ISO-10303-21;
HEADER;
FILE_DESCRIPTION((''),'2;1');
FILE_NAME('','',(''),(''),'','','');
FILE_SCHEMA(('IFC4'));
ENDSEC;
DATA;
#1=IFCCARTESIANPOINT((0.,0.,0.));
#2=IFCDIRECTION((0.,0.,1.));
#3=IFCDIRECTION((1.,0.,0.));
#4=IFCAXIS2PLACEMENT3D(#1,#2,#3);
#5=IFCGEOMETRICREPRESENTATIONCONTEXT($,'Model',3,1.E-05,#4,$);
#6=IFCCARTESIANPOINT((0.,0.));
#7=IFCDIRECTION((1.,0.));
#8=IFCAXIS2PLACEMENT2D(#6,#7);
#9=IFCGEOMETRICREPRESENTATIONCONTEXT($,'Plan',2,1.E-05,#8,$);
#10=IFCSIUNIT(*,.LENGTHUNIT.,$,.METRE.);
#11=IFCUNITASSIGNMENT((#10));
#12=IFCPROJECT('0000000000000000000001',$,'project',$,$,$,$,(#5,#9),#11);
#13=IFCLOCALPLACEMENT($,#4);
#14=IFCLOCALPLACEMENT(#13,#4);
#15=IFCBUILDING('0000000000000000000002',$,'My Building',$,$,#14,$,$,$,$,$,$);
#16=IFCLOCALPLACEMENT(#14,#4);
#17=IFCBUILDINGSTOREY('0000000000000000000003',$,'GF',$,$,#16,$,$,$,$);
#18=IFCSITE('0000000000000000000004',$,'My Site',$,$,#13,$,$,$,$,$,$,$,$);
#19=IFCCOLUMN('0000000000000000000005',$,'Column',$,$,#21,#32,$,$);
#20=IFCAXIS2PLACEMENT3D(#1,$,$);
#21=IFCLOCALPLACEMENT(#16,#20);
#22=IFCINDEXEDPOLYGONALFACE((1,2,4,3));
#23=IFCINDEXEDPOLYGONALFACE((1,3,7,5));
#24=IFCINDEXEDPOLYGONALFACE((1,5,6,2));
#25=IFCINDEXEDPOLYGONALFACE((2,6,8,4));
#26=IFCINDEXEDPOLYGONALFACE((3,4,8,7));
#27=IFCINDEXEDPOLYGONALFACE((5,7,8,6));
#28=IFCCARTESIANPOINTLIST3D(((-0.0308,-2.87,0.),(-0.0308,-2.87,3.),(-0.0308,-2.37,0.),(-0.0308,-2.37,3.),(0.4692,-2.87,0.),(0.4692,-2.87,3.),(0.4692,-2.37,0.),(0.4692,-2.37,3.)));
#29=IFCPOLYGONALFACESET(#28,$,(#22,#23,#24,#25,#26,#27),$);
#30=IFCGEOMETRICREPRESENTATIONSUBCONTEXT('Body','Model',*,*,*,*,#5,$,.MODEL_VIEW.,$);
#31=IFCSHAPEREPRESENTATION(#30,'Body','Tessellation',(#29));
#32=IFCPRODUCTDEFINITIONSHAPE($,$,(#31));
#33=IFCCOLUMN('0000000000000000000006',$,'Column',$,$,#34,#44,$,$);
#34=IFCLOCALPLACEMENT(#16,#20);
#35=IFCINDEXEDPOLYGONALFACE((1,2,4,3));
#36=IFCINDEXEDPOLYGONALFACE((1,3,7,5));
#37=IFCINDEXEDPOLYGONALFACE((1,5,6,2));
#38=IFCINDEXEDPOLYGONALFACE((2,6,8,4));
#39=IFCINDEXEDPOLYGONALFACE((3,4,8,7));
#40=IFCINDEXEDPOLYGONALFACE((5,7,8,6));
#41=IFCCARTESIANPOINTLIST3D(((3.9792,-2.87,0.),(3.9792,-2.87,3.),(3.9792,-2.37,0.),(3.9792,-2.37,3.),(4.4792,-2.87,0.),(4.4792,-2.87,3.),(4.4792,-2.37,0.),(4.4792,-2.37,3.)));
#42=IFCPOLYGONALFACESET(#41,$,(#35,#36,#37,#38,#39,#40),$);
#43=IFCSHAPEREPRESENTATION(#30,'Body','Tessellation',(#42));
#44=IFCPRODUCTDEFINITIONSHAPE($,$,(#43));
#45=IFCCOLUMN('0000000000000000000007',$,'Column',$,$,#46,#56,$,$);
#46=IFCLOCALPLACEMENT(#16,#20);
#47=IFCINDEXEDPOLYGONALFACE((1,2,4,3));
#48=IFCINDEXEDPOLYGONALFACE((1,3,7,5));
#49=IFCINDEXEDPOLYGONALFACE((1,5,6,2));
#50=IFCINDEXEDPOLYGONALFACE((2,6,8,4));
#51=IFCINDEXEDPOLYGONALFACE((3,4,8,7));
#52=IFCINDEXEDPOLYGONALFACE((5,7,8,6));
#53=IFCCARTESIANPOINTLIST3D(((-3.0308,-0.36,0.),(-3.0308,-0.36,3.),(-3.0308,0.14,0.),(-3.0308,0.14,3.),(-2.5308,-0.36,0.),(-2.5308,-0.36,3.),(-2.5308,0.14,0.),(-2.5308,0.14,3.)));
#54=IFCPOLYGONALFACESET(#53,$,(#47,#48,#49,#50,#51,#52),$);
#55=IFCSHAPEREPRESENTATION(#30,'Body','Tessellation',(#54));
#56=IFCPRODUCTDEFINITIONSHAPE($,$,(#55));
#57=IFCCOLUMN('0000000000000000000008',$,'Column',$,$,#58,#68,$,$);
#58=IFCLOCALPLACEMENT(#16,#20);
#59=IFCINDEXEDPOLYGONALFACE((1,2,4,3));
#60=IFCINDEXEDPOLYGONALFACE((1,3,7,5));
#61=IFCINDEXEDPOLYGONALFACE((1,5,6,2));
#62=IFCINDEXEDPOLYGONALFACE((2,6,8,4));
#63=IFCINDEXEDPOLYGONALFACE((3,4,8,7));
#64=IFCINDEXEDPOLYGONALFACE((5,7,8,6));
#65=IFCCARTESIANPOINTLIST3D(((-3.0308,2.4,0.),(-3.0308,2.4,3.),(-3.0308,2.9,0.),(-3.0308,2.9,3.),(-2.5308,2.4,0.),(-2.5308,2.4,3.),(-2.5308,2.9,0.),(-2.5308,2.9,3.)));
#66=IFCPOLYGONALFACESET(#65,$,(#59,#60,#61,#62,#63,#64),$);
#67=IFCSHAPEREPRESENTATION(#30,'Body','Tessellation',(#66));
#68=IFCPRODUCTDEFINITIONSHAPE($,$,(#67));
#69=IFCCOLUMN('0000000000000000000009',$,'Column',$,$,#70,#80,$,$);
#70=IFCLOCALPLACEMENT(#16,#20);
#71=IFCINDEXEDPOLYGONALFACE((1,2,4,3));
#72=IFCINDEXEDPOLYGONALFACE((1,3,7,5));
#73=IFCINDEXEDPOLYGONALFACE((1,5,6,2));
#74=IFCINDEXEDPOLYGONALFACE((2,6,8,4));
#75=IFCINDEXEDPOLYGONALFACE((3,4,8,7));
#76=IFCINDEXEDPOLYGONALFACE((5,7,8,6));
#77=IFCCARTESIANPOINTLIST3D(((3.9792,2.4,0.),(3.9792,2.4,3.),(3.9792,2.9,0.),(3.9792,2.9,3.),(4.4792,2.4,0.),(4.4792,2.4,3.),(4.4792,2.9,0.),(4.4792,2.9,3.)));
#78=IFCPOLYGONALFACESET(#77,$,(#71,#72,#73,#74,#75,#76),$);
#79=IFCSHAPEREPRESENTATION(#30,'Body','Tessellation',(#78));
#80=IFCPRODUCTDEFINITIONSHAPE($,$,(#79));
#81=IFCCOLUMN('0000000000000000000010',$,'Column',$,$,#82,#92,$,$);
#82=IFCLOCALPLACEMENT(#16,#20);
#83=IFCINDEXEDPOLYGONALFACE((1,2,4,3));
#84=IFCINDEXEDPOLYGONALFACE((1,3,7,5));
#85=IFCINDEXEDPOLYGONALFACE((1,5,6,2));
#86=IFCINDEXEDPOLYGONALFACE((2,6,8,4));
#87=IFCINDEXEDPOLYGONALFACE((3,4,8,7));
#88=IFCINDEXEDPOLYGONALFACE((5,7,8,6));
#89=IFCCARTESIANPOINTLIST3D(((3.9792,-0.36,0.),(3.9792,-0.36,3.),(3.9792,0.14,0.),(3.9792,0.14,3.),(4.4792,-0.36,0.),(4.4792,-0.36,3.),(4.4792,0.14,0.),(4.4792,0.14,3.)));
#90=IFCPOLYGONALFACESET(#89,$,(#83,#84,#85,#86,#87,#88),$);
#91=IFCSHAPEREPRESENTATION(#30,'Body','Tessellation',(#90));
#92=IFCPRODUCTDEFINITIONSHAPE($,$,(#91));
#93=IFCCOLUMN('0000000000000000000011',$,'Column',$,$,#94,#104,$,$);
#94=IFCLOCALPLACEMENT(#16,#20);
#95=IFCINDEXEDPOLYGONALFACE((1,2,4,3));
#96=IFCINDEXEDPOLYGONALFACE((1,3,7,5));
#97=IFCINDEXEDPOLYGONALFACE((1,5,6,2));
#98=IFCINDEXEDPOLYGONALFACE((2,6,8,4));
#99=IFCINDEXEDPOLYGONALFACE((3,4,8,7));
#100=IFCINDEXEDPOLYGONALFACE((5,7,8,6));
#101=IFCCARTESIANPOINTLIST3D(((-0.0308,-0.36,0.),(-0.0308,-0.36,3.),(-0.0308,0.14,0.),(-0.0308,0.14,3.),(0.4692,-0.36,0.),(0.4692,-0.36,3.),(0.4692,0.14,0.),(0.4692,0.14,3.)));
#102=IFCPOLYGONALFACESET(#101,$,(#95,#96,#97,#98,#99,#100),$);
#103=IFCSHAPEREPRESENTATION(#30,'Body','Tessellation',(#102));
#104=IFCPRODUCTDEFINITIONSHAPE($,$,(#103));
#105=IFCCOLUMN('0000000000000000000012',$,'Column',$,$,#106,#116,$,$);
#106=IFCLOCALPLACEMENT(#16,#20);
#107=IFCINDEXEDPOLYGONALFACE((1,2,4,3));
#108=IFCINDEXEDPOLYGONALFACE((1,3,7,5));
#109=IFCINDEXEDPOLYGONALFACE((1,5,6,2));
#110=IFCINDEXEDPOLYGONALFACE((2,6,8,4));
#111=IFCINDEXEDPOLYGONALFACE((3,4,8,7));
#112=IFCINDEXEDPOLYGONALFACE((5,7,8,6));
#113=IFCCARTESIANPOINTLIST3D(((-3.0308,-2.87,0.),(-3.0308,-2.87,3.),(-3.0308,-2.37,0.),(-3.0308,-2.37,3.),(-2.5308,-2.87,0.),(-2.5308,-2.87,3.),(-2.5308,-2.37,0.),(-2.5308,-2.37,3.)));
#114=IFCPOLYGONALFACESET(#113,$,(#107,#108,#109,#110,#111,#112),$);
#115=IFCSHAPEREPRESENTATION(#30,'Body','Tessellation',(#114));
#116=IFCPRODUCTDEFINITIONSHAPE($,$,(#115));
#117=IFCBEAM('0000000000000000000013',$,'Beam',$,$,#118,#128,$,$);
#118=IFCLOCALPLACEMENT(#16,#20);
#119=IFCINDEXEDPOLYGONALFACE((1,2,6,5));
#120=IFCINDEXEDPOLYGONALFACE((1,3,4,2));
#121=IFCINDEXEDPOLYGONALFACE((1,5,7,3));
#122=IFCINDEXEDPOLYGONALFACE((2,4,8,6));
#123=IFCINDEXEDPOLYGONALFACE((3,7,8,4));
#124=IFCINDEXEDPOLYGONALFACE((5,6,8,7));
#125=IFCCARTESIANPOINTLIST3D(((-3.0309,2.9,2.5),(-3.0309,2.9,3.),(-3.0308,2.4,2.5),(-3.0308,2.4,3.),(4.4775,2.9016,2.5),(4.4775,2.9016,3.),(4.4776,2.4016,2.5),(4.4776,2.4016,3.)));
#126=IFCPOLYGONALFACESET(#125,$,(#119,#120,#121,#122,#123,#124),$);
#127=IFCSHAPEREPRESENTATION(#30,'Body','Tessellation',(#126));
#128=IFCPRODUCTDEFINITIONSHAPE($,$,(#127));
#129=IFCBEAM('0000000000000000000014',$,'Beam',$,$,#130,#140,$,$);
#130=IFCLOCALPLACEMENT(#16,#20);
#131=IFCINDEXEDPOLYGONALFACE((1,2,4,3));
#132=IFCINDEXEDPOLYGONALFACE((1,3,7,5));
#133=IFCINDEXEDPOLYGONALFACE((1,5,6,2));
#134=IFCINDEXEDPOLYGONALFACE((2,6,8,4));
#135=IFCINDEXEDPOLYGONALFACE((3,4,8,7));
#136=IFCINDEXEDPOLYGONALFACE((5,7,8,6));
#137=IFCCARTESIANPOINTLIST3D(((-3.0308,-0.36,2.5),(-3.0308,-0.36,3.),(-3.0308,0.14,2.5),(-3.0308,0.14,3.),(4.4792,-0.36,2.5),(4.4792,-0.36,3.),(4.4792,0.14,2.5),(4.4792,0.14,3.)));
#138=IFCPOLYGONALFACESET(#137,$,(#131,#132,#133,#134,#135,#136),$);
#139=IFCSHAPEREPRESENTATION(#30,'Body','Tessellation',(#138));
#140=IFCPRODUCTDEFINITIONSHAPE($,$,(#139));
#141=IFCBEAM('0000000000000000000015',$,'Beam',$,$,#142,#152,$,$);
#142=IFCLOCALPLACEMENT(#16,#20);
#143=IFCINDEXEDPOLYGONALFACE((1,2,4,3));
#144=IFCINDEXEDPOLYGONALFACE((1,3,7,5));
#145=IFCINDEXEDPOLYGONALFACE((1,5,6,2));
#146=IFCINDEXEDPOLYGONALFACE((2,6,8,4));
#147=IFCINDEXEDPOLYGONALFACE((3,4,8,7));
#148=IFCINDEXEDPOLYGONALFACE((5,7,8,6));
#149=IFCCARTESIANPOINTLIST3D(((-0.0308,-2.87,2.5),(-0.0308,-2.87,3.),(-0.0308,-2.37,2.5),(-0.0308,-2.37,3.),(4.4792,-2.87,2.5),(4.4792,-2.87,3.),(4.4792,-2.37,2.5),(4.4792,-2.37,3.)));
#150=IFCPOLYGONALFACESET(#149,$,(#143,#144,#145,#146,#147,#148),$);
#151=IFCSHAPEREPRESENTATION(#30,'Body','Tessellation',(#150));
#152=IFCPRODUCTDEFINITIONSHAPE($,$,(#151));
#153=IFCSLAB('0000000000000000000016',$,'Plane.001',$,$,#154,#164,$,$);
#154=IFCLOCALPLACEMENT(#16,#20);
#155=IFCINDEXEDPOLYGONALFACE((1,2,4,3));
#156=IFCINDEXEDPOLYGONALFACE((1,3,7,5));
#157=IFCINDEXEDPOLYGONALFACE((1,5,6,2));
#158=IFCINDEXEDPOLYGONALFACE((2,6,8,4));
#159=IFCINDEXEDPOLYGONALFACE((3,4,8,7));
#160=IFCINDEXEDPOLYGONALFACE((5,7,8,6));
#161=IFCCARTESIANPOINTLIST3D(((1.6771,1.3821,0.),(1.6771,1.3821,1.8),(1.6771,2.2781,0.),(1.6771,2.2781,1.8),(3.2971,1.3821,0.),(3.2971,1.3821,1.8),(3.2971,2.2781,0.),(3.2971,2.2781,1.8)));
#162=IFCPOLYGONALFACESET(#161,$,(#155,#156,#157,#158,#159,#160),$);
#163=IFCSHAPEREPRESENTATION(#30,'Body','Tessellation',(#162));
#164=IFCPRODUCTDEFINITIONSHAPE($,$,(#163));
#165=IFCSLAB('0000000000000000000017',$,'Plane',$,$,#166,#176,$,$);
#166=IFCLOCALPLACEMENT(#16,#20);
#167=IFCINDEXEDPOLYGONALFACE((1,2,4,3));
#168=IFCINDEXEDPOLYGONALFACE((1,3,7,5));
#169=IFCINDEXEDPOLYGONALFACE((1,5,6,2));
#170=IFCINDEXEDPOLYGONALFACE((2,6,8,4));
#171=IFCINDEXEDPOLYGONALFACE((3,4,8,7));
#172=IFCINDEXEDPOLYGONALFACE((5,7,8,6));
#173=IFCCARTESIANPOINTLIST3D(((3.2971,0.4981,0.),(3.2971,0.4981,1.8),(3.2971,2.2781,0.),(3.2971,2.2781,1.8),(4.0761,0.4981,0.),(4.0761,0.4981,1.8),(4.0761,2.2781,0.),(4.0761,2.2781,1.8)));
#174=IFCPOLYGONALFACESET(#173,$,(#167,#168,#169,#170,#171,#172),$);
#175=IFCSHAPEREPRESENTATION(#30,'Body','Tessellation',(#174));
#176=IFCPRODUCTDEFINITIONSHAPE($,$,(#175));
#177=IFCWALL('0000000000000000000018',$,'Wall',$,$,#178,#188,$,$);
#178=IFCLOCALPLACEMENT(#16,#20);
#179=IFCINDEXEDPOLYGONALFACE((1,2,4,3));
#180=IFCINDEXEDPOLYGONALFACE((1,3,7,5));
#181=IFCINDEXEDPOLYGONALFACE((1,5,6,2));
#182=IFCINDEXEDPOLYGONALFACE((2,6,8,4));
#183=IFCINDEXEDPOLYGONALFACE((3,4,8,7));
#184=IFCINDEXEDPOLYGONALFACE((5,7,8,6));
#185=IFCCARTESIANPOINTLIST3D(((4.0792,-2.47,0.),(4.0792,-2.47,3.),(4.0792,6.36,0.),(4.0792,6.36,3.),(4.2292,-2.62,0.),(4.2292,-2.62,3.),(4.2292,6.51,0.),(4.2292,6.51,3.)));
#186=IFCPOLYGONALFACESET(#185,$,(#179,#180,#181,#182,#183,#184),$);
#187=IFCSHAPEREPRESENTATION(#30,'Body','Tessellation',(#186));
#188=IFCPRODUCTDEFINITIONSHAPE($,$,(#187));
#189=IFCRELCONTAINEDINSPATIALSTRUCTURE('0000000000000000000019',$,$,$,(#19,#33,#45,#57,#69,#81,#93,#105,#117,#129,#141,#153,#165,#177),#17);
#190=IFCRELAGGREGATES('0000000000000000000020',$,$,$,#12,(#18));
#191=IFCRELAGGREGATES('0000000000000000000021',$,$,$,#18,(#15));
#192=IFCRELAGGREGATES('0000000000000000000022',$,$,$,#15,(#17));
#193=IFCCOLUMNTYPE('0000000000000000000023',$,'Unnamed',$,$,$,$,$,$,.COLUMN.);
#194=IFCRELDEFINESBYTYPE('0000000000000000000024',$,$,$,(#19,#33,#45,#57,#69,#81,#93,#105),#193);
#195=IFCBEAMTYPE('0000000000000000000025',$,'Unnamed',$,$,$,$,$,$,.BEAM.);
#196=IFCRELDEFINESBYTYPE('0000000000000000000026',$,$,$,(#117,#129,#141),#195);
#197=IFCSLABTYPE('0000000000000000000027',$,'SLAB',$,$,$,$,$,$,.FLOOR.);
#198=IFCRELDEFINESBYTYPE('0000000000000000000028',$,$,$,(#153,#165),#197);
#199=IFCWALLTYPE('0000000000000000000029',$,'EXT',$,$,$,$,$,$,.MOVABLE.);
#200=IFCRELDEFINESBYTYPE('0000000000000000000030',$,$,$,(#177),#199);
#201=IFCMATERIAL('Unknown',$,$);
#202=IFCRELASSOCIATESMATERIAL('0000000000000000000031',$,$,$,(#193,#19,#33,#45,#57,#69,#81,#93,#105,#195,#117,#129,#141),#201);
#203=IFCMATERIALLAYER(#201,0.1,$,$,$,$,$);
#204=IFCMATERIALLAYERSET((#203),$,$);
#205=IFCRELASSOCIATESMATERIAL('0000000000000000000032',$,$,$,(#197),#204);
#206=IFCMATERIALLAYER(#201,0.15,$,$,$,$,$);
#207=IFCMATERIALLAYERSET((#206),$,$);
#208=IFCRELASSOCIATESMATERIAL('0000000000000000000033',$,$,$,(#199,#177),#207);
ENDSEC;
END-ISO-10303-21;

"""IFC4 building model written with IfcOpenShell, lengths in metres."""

from ifc_helpers import new_model, si_unit, frame, origin_with_axes, origin_2d_with_axis, place, context, subcontext, project, spatial, line, indexed_curve, rectangle, outline, extrude, material, layer, layer_set, layer_usage, material_profile, profile_set, profile_usage, type_object, element, save


model = new_model("IFC4")

# Units and contexts
model_context = context("Model", 3, precision=1e-05, world=origin_with_axes())
plan_context = context("Plan", 2, precision=1e-05, world=origin_2d_with_axis())
body_context_1 = subcontext(model_context, "Body", "Model", "MODEL_VIEW")
ifc_project = project(units=[si_unit("LENGTHUNIT", "METRE")], contexts=[model_context, plan_context])

# Site, building, storey
site_placement = place(None, origin_with_axes())
site = spatial("IfcSite", under=ifc_project, at=site_placement, Name="My Site")
building_placement = place(site_placement, origin_with_axes())
building = spatial("IfcBuilding", under=site, at=building_placement, Name="My Building")
storey_placement = place(building_placement, origin_with_axes())
storey = spatial("IfcBuildingStorey", under=building, at=storey_placement, Name="GF")

# Columns
ifc_material = material(Name="Unknown")
ifc_material_profile_1 = material_profile(ifc_material, rectangle(XDim=0.5, YDim=0.5))
ifc_profile_set_1 = profile_set([ifc_material_profile_1])
ifc_profile_usage_1 = profile_usage(ifc_profile_set_1, cardinal=5)
column_type = type_object("IfcColumnType", Name="Unnamed", PredefinedType="COLUMN", material=ifc_profile_set_1)
column_1_placement = place(storey_placement, frame((0.2192, -2.62, 0.0), z_axis=(0.0, 0.0, 1.0), x_axis=(1.0, 0.0, 0.0)))
element("IfcColumn", 1, at=column_1_placement, inside=storey, type_object=column_type, material=ifc_profile_usage_1, Name="Column", context=body_context_1, shape_type="SweptSolid", body=[
    extrude(rectangle(XDim=0.5, YDim=0.5), origin_with_axes(), (0.0, 0.0, 1.0), 3.0),
])
ifc_profile_usage_2 = profile_usage(ifc_profile_set_1, cardinal=5)
column_2_placement = place(storey_placement, frame((4.2292, -2.62, 0.0), z_axis=(0.0, 0.0, 1.0), x_axis=(1.0, 0.0, 0.0)))
element("IfcColumn", 2, at=column_2_placement, inside=storey, type_object=column_type, material=ifc_profile_usage_2, Name="Column", context=body_context_1, shape_type="SweptSolid", body=[
    extrude(rectangle(XDim=0.5, YDim=0.5), origin_with_axes(), (0.0, 0.0, 1.0), 3.0),
])
ifc_profile_usage_3 = profile_usage(ifc_profile_set_1, cardinal=5)
column_3_placement = place(storey_placement, frame((-2.7808, -0.11, 0.0), z_axis=(0.0, 0.0, 1.0), x_axis=(1.0, 0.0, 0.0)))
element("IfcColumn", 3, at=column_3_placement, inside=storey, type_object=column_type, material=ifc_profile_usage_3, Name="Column", context=body_context_1, shape_type="SweptSolid", body=[
    extrude(rectangle(XDim=0.5, YDim=0.5), origin_with_axes(), (0.0, 0.0, 1.0), 3.0),
])
ifc_profile_usage_4 = profile_usage(ifc_profile_set_1, cardinal=5)
column_4_placement = place(storey_placement, frame((-2.7808, 2.65, 0.0), z_axis=(0.0, 0.0, 1.0), x_axis=(1.0, 0.0, 0.0)))
element("IfcColumn", 4, at=column_4_placement, inside=storey, type_object=column_type, material=ifc_profile_usage_4, Name="Column", context=body_context_1, shape_type="SweptSolid", body=[
    extrude(rectangle(XDim=0.5, YDim=0.5), origin_with_axes(), (0.0, 0.0, 1.0), 3.0),
])
ifc_profile_usage_5 = profile_usage(ifc_profile_set_1, cardinal=5)
column_5_placement = place(storey_placement, frame((4.2292, 2.65, 0.0), z_axis=(0.0, 0.0, 1.0), x_axis=(1.0, 0.0, 0.0)))
element("IfcColumn", 5, at=column_5_placement, inside=storey, type_object=column_type, material=ifc_profile_usage_5, Name="Column", context=body_context_1, shape_type="SweptSolid", body=[
    extrude(rectangle(XDim=0.5, YDim=0.5), origin_with_axes(), (0.0, 0.0, 1.0), 3.0),
])
ifc_profile_usage_6 = profile_usage(ifc_profile_set_1, cardinal=5)
column_6_placement = place(storey_placement, frame((4.2292, -0.11, 0.0), z_axis=(0.0, 0.0, 1.0), x_axis=(1.0, 0.0, 0.0)))
element("IfcColumn", 6, at=column_6_placement, inside=storey, type_object=column_type, material=ifc_profile_usage_6, Name="Column", context=body_context_1, shape_type="SweptSolid", body=[
    extrude(rectangle(XDim=0.5, YDim=0.5), origin_with_axes(), (0.0, 0.0, 1.0), 3.0),
])
ifc_profile_usage_7 = profile_usage(ifc_profile_set_1, cardinal=5)
column_7_placement = place(storey_placement, frame((0.2192, -0.11, 0.0), z_axis=(0.0, 0.0, 1.0), x_axis=(1.0, 0.0, 0.0)))
element("IfcColumn", 7, at=column_7_placement, inside=storey, type_object=column_type, material=ifc_profile_usage_7, Name="Column", context=body_context_1, shape_type="SweptSolid", body=[
    extrude(rectangle(XDim=0.5, YDim=0.5), origin_with_axes(), (0.0, 0.0, 1.0), 3.0),
])
ifc_profile_usage_8 = profile_usage(ifc_profile_set_1, cardinal=5)
column_8_placement = place(storey_placement, frame((-2.7808, -2.62, 0.0), z_axis=(0.0, 0.0, 1.0), x_axis=(1.0, 0.0, 0.0)))
element("IfcColumn", 8, at=column_8_placement, inside=storey, type_object=column_type, material=ifc_profile_usage_8, Name="Column", context=body_context_1, shape_type="SweptSolid", body=[
    extrude(rectangle(XDim=0.5, YDim=0.5), origin_with_axes(), (0.0, 0.0, 1.0), 3.0),
])

# Beams
ifc_material_profile_2 = material_profile(ifc_material, rectangle(XDim=0.5, YDim=0.5))
ifc_profile_set_2 = profile_set([ifc_material_profile_2])
ifc_profile_usage_9 = profile_usage(ifc_profile_set_2, cardinal=7)
beam_type = type_object("IfcBeamType", Name="Unnamed", PredefinedType="BEAM", material=ifc_profile_set_2)
beam_1_placement = place(storey_placement, frame((4.4776, 2.4016, 3.0), z_axis=(-1.0, -0.000217, 0.0), x_axis=(0.000217, -1.0, 0.0)))
element("IfcBeam", 9, at=beam_1_placement, inside=storey, type_object=beam_type, material=ifc_profile_usage_9, Name="Beam", context=body_context_1, shape_type="SweptSolid", body=[
    extrude(rectangle(XDim=0.5, YDim=0.5), frame((-0.25, -0.25, 0.0), z_axis=(0.0, 0.0, 1.0), x_axis=(1.0, 0.0, 0.0)), (0.0, 0.0, 1.0), 7.5084),
])
ifc_profile_usage_10 = profile_usage(ifc_profile_set_2, cardinal=7)
beam_2_placement = place(storey_placement, frame((4.4792, -0.36, 3.0), z_axis=(-1.0, 0.0, 0.0), x_axis=(0.0, -1.0, 0.0)))
element("IfcBeam", 10, at=beam_2_placement, inside=storey, type_object=beam_type, material=ifc_profile_usage_10, Name="Beam", context=body_context_1, shape_type="SweptSolid", body=[
    extrude(rectangle(XDim=0.5, YDim=0.5), frame((-0.25, -0.25, 0.0), z_axis=(0.0, 0.0, 1.0), x_axis=(1.0, 0.0, 0.0)), (0.0, 0.0, 1.0), 7.51),
])
ifc_profile_usage_11 = profile_usage(ifc_profile_set_2, cardinal=7)
beam_3_placement = place(storey_placement, frame((4.4792, -2.87, 3.0), z_axis=(-1.0, -0.000001, 0.000001), x_axis=(0.000001, -1.0, 0.0)))
element("IfcBeam", 11, at=beam_3_placement, inside=storey, type_object=beam_type, material=ifc_profile_usage_11, Name="Beam", context=body_context_1, shape_type="SweptSolid", body=[
    extrude(rectangle(XDim=0.5, YDim=0.5), frame((-0.25, -0.25, 0.0), z_axis=(0.0, 0.0, 1.0), x_axis=(1.0, 0.0, 0.0)), (0.0, 0.0, 1.0), 4.51),
])

# Slabs
ifc_layer_1 = layer(ifc_material, 0.1)
ifc_layer_set_1 = layer_set([ifc_layer_1])
slab_type = type_object("IfcSlabType", Name="SLAB", PredefinedType="FLOOR", material=ifc_layer_set_1)
slab_1_placement = place(storey_placement, frame((2.4871, 1.8301, 0.0), z_axis=(0.0, 0.0, 1.0), x_axis=(1.0, 0.0, 0.0)))
element("IfcSlab", 12, at=slab_1_placement, inside=storey, type_object=slab_type, Name="Plane.001", context=body_context_1, shape_type="SweptSolid", body=[
    extrude(outline(indexed_curve([(-0.81, -0.448), (0.81, -0.448), (0.81, 0.448), (-0.81, 0.448), (-0.81, -0.448)])), origin_with_axes(), (0.0, 0.0, 1.0), 1.8),
])
slab_2_placement = place(storey_placement, frame((3.6866, 1.3881, 0.0), z_axis=(0.0, 0.0, 1.0), x_axis=(1.0, 0.0, 0.0)))
element("IfcSlab", 13, at=slab_2_placement, inside=storey, type_object=slab_type, Name="Plane", context=body_context_1, shape_type="SweptSolid", body=[
    extrude(outline(indexed_curve([(-0.3895, -0.89), (0.3895, -0.89), (0.3895, 0.89), (-0.3895, 0.89), (-0.3895, -0.89)])), origin_with_axes(), (0.0, 0.0, 1.0), 1.8),
])

# Shared definitions
ifc_layer_2 = layer(ifc_material, 0.15)
ifc_layer_set_2 = layer_set([ifc_layer_2])
wall_type_1 = type_object("IfcWallType", Name="EXT", PredefinedType="MOVABLE", material=ifc_layer_set_2)

# Wall
ifc_layer_usage_1 = layer_usage(ifc_layer_set_2, "AXIS2", "POSITIVE", 0.0)
wall_1_placement = place(storey_placement, frame((4.2292, -2.62, 0.0), z_axis=(0.0, 0.0, 1.0), x_axis=(0.0, 1.0, 0.0)))
element("IfcWall", 14, at=wall_1_placement, inside=storey, type_object=wall_type_1, material=ifc_layer_usage_1, Name="Wall", context=body_context_1, shape_type="SweptSolid", body=[
    extrude(outline(indexed_curve([(0.0, 0.0), (0.15, 0.15), (8.98, 0.15), (9.13, 0.0)], segments=[line(1, 2, 3, 4, 1)])), origin_with_axes(), (0.0, 0.0, 1.0), 3.0),
])

save(model, "model.ifc")
